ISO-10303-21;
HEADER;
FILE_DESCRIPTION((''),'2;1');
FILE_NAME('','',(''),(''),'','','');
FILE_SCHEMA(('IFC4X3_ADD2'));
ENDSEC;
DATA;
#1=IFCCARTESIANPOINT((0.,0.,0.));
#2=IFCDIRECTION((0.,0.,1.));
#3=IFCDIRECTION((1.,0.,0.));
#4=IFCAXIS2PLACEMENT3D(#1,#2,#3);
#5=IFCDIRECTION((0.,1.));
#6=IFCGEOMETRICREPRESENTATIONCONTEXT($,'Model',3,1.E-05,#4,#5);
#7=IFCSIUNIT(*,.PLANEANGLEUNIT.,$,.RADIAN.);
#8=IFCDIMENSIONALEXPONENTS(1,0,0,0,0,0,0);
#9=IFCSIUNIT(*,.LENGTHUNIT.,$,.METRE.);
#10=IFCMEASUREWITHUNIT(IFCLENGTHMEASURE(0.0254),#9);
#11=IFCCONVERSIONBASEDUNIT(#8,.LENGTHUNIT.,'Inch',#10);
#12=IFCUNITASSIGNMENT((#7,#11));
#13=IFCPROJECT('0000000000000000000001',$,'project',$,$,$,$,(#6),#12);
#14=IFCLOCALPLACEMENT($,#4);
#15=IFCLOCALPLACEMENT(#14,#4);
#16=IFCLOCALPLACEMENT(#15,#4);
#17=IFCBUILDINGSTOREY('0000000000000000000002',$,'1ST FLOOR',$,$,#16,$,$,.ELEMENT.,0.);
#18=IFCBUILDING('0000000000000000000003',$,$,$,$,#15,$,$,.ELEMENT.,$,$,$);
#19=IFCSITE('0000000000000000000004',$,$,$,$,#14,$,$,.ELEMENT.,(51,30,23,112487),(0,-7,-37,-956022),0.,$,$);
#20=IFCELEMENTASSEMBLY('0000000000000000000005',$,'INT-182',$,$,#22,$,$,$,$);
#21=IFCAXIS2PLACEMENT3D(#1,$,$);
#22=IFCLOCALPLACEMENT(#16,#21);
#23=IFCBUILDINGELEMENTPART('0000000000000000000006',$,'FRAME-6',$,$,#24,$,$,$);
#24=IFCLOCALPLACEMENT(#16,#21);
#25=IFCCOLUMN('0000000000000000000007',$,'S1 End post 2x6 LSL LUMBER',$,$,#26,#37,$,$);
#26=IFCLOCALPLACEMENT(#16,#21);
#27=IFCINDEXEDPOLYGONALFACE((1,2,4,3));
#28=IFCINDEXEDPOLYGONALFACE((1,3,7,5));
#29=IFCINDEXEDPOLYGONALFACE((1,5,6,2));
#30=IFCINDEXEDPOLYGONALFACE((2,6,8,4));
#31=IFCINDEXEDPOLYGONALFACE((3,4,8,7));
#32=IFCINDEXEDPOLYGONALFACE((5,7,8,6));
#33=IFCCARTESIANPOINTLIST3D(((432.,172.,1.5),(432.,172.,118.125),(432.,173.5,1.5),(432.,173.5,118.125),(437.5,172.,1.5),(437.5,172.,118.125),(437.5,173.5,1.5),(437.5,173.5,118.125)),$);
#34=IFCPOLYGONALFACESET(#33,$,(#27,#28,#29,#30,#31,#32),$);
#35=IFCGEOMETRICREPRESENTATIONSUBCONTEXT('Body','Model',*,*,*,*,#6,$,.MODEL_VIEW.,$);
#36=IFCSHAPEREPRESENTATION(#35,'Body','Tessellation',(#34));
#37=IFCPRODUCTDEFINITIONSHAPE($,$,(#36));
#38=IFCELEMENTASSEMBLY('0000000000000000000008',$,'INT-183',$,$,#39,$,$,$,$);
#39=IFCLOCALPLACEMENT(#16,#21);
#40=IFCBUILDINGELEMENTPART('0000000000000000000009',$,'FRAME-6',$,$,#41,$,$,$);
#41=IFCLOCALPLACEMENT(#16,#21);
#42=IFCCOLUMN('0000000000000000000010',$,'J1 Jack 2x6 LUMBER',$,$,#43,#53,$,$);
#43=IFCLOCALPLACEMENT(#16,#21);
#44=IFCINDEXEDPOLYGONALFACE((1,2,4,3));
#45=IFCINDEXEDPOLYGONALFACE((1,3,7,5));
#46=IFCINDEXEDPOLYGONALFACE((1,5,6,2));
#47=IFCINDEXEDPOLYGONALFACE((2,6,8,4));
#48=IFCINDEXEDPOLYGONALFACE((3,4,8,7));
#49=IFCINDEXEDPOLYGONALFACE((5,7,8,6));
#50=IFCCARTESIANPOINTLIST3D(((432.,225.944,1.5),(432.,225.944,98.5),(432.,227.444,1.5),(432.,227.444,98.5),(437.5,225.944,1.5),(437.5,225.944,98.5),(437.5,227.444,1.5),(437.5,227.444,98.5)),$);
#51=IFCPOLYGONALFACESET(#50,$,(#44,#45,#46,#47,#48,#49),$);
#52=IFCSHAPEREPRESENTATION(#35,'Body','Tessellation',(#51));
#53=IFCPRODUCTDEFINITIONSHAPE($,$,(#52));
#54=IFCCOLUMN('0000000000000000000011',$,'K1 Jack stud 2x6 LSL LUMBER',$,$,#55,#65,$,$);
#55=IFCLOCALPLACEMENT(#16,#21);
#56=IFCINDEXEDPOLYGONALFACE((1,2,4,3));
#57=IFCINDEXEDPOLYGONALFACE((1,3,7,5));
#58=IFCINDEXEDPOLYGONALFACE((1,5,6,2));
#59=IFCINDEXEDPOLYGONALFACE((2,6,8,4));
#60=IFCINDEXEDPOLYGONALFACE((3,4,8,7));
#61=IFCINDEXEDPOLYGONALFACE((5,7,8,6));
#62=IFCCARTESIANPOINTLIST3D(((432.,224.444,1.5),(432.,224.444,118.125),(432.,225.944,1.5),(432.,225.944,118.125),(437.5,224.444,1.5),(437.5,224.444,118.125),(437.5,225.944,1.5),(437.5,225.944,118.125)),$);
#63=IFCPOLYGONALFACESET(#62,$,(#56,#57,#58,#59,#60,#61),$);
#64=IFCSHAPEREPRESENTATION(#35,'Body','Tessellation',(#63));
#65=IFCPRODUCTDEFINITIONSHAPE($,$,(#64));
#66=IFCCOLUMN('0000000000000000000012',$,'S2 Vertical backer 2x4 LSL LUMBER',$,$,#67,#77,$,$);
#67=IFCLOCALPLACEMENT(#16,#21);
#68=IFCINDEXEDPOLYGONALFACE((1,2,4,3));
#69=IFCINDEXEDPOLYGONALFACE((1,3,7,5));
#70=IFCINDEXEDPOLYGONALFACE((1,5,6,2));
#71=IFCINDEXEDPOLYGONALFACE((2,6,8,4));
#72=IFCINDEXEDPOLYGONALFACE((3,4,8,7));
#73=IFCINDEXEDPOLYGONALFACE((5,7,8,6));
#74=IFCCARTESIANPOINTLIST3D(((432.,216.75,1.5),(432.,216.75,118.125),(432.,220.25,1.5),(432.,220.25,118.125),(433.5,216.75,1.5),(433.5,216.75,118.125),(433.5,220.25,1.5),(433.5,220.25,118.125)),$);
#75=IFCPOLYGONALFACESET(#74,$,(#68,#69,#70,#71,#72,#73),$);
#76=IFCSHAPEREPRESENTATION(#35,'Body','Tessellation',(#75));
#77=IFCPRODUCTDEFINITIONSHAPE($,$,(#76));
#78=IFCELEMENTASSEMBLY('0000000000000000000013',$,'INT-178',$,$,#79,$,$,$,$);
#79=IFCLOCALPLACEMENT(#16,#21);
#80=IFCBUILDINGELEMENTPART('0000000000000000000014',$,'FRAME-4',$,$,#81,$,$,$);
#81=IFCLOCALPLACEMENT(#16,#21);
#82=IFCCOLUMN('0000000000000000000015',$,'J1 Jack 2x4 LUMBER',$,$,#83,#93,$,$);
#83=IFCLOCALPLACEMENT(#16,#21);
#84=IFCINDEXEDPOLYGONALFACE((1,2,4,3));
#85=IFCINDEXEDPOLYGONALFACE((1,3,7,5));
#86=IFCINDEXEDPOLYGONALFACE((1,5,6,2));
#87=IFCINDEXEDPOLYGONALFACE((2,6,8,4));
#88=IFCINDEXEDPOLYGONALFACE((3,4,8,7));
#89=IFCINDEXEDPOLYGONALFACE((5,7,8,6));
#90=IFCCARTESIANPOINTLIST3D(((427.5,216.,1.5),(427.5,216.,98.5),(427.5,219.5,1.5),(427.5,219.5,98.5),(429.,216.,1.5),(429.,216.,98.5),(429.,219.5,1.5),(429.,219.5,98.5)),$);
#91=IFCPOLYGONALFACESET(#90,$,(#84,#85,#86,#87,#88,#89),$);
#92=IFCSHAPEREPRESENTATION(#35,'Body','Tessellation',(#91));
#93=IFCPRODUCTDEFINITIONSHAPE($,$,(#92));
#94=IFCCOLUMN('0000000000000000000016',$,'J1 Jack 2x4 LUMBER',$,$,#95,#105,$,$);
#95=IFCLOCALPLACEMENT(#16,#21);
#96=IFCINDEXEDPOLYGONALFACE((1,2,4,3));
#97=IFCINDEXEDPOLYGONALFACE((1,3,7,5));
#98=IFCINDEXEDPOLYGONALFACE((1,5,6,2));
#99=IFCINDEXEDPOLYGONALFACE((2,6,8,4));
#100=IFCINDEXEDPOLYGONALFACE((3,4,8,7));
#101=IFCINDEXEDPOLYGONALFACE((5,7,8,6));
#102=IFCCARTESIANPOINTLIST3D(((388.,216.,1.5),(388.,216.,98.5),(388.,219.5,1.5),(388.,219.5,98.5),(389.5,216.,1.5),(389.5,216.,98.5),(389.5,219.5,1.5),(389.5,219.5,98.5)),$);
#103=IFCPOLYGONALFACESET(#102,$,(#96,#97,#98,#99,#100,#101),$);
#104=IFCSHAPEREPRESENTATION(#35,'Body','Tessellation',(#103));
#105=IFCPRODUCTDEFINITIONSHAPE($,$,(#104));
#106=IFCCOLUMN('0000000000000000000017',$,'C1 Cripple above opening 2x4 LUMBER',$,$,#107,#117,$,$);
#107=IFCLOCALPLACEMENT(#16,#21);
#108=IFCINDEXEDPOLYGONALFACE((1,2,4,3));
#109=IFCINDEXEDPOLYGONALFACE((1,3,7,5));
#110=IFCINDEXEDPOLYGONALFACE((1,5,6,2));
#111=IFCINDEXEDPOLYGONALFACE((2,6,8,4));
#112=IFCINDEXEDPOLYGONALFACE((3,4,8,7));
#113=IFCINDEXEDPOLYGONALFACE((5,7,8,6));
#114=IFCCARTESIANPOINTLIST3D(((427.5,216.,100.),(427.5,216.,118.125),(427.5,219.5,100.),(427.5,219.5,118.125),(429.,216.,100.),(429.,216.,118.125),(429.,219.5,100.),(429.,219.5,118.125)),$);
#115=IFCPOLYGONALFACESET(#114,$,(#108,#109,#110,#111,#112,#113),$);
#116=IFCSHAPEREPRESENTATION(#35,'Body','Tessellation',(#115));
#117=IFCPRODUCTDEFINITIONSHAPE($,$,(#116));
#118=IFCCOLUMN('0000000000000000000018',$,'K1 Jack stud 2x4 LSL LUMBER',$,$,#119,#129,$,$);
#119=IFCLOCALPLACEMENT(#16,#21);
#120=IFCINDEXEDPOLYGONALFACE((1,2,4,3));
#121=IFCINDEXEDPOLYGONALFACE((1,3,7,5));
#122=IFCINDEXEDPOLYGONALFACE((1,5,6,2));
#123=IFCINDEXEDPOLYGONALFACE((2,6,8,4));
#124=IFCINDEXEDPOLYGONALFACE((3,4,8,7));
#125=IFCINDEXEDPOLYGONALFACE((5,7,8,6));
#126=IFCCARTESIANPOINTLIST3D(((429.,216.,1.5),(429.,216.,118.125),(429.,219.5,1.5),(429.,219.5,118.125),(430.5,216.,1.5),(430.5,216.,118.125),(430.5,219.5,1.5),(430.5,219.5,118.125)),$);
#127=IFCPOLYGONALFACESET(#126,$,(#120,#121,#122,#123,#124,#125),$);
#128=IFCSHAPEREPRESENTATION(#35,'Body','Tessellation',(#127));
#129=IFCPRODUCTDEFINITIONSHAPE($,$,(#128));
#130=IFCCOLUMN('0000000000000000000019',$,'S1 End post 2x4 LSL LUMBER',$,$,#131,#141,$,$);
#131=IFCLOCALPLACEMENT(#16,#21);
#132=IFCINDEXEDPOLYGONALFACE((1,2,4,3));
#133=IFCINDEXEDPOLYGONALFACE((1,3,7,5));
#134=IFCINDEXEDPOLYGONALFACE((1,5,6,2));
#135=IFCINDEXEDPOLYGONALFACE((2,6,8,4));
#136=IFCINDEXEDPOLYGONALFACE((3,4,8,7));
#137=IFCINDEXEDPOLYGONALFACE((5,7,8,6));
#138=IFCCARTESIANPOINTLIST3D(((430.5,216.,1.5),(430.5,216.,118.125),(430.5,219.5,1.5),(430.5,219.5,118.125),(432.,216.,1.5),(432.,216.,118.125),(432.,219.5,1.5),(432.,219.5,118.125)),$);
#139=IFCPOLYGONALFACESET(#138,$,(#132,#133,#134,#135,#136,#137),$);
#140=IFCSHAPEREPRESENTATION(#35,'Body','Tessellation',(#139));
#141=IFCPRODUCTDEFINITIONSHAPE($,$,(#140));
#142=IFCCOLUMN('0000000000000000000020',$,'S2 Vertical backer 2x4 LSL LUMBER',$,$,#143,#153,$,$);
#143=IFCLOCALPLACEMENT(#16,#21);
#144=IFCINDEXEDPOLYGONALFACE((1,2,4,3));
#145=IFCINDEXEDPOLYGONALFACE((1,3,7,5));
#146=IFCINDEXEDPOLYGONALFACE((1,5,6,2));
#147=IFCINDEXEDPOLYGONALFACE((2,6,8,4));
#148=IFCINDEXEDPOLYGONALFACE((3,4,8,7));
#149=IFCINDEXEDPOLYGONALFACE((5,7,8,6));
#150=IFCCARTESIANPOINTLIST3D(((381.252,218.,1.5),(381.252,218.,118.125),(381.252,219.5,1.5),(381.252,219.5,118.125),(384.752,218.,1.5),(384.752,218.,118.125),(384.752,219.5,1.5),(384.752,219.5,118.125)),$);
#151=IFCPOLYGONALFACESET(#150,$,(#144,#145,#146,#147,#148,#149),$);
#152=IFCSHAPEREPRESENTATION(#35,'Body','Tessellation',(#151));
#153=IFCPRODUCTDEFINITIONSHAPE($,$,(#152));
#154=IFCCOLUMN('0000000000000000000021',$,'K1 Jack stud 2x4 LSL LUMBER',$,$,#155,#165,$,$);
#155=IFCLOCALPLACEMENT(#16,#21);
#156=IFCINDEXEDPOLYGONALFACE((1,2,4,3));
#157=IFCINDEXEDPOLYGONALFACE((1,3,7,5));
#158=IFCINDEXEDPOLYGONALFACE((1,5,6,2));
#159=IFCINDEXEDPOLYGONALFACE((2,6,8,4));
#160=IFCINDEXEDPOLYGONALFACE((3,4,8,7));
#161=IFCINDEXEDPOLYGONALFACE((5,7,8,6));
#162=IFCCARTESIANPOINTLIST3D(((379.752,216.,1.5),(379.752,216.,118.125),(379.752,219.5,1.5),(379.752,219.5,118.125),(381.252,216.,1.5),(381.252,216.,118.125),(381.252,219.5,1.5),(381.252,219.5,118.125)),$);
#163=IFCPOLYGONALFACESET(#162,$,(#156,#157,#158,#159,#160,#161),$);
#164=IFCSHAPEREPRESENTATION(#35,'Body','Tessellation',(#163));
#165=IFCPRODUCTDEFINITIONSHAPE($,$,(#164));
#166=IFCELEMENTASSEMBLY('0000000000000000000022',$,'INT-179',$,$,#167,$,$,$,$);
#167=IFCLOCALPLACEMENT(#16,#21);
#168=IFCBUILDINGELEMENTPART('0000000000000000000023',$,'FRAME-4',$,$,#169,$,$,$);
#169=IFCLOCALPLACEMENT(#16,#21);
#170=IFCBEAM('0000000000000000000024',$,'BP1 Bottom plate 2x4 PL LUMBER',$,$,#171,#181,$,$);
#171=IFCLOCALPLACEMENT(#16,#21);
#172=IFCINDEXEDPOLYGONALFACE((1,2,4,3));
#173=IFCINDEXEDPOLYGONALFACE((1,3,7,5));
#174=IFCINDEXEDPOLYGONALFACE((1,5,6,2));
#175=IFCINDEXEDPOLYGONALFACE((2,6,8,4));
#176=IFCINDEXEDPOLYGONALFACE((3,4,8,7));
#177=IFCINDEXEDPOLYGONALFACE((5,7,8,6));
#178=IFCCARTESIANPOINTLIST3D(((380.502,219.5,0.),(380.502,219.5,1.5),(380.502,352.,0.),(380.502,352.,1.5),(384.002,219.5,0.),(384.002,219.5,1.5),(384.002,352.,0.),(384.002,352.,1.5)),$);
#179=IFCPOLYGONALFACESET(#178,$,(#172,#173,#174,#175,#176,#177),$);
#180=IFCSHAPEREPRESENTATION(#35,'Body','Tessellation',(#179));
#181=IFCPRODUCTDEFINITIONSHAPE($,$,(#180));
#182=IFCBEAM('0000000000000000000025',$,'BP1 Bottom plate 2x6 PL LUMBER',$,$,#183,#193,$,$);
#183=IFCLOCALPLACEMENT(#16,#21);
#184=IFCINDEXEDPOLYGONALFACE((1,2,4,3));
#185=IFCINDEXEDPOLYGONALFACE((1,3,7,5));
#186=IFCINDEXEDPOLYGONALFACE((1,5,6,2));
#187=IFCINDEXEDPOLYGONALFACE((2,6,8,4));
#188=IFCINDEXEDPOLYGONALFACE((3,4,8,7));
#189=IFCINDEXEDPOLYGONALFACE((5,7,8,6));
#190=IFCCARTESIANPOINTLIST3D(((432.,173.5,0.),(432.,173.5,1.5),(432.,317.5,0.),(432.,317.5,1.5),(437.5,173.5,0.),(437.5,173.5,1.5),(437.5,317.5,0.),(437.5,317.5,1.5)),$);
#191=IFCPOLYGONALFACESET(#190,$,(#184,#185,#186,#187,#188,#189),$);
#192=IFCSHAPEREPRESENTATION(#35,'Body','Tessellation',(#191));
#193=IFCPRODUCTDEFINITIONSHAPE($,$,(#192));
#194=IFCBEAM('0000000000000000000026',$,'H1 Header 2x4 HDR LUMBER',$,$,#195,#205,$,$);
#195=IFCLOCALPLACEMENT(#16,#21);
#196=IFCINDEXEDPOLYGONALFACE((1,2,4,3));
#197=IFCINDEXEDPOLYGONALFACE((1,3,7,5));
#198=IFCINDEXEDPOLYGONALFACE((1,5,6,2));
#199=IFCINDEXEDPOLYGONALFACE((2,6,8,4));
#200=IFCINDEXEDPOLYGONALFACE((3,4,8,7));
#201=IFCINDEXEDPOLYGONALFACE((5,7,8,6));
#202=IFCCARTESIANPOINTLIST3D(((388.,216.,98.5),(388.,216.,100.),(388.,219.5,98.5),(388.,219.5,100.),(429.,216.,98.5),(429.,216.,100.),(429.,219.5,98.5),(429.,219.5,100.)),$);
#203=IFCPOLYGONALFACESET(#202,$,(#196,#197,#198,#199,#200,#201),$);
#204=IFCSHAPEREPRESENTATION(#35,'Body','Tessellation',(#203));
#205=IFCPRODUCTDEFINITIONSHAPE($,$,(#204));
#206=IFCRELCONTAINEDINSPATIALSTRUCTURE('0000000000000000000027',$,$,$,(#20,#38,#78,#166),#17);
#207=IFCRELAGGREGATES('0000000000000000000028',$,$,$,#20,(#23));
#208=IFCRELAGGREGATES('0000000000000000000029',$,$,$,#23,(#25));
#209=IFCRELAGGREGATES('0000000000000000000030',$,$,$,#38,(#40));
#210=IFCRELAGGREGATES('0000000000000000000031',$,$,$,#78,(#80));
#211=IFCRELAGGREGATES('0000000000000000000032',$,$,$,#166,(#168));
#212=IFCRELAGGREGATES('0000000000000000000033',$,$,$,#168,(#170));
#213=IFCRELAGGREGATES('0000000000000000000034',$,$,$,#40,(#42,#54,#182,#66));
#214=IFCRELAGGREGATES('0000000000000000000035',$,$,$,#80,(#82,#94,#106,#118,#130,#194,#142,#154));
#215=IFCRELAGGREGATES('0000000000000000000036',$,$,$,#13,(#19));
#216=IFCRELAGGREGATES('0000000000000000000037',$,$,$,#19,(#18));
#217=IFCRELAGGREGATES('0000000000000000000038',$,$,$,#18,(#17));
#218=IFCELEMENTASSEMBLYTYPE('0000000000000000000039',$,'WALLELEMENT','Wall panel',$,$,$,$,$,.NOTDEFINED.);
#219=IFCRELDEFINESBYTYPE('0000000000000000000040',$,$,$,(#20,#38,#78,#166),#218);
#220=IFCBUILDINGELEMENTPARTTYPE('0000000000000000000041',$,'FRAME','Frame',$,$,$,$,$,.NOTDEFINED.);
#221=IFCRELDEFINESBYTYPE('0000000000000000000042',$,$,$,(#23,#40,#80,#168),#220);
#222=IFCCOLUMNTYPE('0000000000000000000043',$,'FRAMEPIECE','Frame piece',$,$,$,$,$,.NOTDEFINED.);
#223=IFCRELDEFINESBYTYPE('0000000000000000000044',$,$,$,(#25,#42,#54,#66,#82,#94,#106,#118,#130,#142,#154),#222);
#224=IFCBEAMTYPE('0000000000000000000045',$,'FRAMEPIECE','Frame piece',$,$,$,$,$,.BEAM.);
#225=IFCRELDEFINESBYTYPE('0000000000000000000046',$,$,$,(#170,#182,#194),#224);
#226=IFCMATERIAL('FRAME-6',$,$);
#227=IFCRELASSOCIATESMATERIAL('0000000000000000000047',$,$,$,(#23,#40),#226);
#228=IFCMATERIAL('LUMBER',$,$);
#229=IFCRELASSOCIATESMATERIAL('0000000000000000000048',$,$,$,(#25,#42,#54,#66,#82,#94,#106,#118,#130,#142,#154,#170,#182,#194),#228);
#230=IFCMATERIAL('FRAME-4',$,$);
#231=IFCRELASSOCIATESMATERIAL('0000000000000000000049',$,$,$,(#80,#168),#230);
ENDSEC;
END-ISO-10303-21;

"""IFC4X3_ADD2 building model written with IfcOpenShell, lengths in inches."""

from ifc_helpers import new_model, entity, si_unit, converted_unit, direction, frame, origin_with_axes, origin_2d_with_axis, place, context, subcontext, project, spatial, rectangle, extrude, material, type_object, element, aggregate, save


model = new_model("IFC4X3_ADD2")

# Units and contexts
model_context = context("Model", 3, precision=1e-05, world=origin_with_axes(), true_north=direction((0.0, 1.0)))
body_context = subcontext(model_context, "Body", "Model", "MODEL_VIEW")
ifc_project = project(units=[si_unit("PLANEANGLEUNIT", "RADIAN"), converted_unit("LENGTHUNIT", "Inch", entity("IfcLengthMeasure", 0.0254), si_unit("LENGTHUNIT", "METRE"), dimensions=[1, 0, 0, 0, 0, 0, 0])], contexts=[model_context])

# Site, building, storey
site_placement = place(None, origin_with_axes())
site = spatial("IfcSite", under=ifc_project, at=site_placement, CompositionType="ELEMENT", RefLatitude=(51, 30, 23, 112487), RefLongitude=(0, -7, -37, -956022), RefElevation=0.0)
building_placement = place(site_placement, origin_with_axes())
building = spatial("IfcBuilding", under=site, at=building_placement, CompositionType="ELEMENT")
storey_placement = place(building_placement, origin_with_axes())
storey = spatial("IfcBuildingStorey", under=building, at=storey_placement, Name="1ST FLOOR", CompositionType="ELEMENT", Elevation=0.0)

# Element assembly, building element part, column
element_assembly_type_1 = type_object("IfcElementAssemblyType", Name="WALLELEMENT", Description="Wall panel", PredefinedType="NOTDEFINED")
assembly_1_placement = place(storey_placement, origin_with_axes())
assembly_1 = element("IfcElementAssembly", 1, at=assembly_1_placement, inside=storey, type_object=element_assembly_type_1, Name="INT-182")
ifc_material_1 = material(Name="FRAME-6")
building_element_part_type = type_object("IfcBuildingElementPartType", Name="FRAME", Description="Frame", PredefinedType="NOTDEFINED")
building_element_part_1_placement = place(storey_placement, origin_with_axes())
building_element_part_1 = element("IfcBuildingElementPart", 2, at=building_element_part_1_placement, type_object=building_element_part_type, material=ifc_material_1, Name="FRAME-6")
aggregate(assembly_1, [building_element_part_1])
ifc_material_2 = material(Name="LUMBER")
column_type = type_object("IfcColumnType", Name="FRAMEPIECE", Description="Frame piece", PredefinedType="NOTDEFINED")
column_1_placement = place(storey_placement, frame((434.75, 172.75, 1.5), z_axis=(0.0, 0.0, 1.0), x_axis=(0.0, -1.0, 0.0)))
column_1 = element("IfcColumn", 3, at=column_1_placement, type_object=column_type, material=ifc_material_2, Name="S1 End post 2x6 LSL LUMBER", context=body_context, shape_type="SweptSolid", body=[
    extrude(rectangle(XDim=1.5, YDim=5.5, at=origin_2d_with_axis()), origin_with_axes(), (0.0, 0.0, 1.0), 116.625),
])
aggregate(building_element_part_1, [column_1])

# Element assemblies, building element parts, columns
assembly_2_placement = place(storey_placement, origin_with_axes())
assembly_2 = element("IfcElementAssembly", 4, at=assembly_2_placement, inside=storey, type_object=element_assembly_type_1, Name="INT-183")
building_element_part_2_placement = place(storey_placement, origin_with_axes())
building_element_part_2 = element("IfcBuildingElementPart", 5, at=building_element_part_2_placement, type_object=building_element_part_type, material=ifc_material_1, Name="FRAME-6")
aggregate(assembly_2, [building_element_part_2])
column_2_placement = place(storey_placement, frame((434.75, 226.694, 98.5), z_axis=(0.0, 0.0, -1.0), x_axis=(0.0, 1.0, 0.0)))
column_2 = element("IfcColumn", 6, at=column_2_placement, type_object=column_type, material=ifc_material_2, Name="J1 Jack 2x6 LUMBER", context=body_context, shape_type="SweptSolid", body=[
    extrude(rectangle(XDim=1.5, YDim=5.5, at=origin_2d_with_axis()), origin_with_axes(), (0.0, 0.0, 1.0), 97.0),
])
column_3_placement = place(storey_placement, frame((434.75, 225.194, 118.125), z_axis=(0.0, 0.0, -1.0), x_axis=(0.0, 1.0, 0.0)))
column_3 = element("IfcColumn", 7, at=column_3_placement, type_object=column_type, material=ifc_material_2, Name="K1 Jack stud 2x6 LSL LUMBER", context=body_context, shape_type="SweptSolid", body=[
    extrude(rectangle(XDim=1.5, YDim=5.5, at=origin_2d_with_axis()), origin_with_axes(), (0.0, 0.0, 1.0), 116.625),
])
column_4_placement = place(storey_placement, frame((432.75, 218.5, 1.5), z_axis=(0.0, 0.0, 1.0), x_axis=(-1.0, 0.0, 0.0)))
column_4 = element("IfcColumn", 8, at=column_4_placement, type_object=column_type, material=ifc_material_2, Name="S2 Vertical backer 2x4 LSL LUMBER", context=body_context, shape_type="SweptSolid", body=[
    extrude(rectangle(XDim=1.5, YDim=3.5, at=origin_2d_with_axis()), origin_with_axes(), (0.0, 0.0, 1.0), 116.625),
])
assembly_3_placement = place(storey_placement, origin_with_axes())
assembly_3 = element("IfcElementAssembly", 9, at=assembly_3_placement, inside=storey, type_object=element_assembly_type_1, Name="INT-178")
ifc_material_3 = material(Name="FRAME-4")
building_element_part_3_placement = place(storey_placement, origin_with_axes())
building_element_part_3 = element("IfcBuildingElementPart", 10, at=building_element_part_3_placement, type_object=building_element_part_type, material=ifc_material_3, Name="FRAME-4")
aggregate(assembly_3, [building_element_part_3])
column_5_placement = place(storey_placement, frame((428.25, 217.75, 1.5), z_axis=(0.0, 0.0, 1.0), x_axis=(-1.0, 0.0, 0.0)))
column_5 = element("IfcColumn", 11, at=column_5_placement, type_object=column_type, material=ifc_material_2, Name="J1 Jack 2x4 LUMBER", context=body_context, shape_type="SweptSolid", body=[
    extrude(rectangle(XDim=1.5, YDim=3.5, at=origin_2d_with_axis()), origin_with_axes(), (0.0, 0.0, 1.0), 97.0),
])
column_6_placement = place(storey_placement, frame((388.75, 217.75, 98.5), z_axis=(0.0, 0.0, -1.0), x_axis=(1.0, 0.0, 0.0)))
column_6 = element("IfcColumn", 12, at=column_6_placement, type_object=column_type, material=ifc_material_2, Name="J1 Jack 2x4 LUMBER", context=body_context, shape_type="SweptSolid", body=[
    extrude(rectangle(XDim=1.5, YDim=3.5, at=origin_2d_with_axis()), origin_with_axes(), (0.0, 0.0, 1.0), 97.0),
])
column_7_placement = place(storey_placement, frame((428.25, 217.75, 100.0), z_axis=(0.0, 0.0, 1.0), x_axis=(-1.0, 0.0, 0.0)))
column_7 = element("IfcColumn", 13, at=column_7_placement, type_object=column_type, material=ifc_material_2, Name="C1 Cripple above opening 2x4 LUMBER", context=body_context, shape_type="SweptSolid", body=[
    extrude(rectangle(XDim=1.5, YDim=3.5, at=origin_2d_with_axis()), origin_with_axes(), (0.0, 0.0, 1.0), 18.125),
])
column_8_placement = place(storey_placement, frame((429.75, 217.75, 1.5), z_axis=(0.0, 0.0, 1.0), x_axis=(-1.0, 0.0, 0.0)))
column_8 = element("IfcColumn", 14, at=column_8_placement, type_object=column_type, material=ifc_material_2, Name="K1 Jack stud 2x4 LSL LUMBER", context=body_context, shape_type="SweptSolid", body=[
    extrude(rectangle(XDim=1.5, YDim=3.5, at=origin_2d_with_axis()), origin_with_axes(), (0.0, 0.0, 1.0), 116.625),
])
column_9_placement = place(storey_placement, frame((431.25, 217.75, 1.5), z_axis=(0.0, 0.0, 1.0), x_axis=(-1.0, 0.0, 0.0)))
column_9 = element("IfcColumn", 15, at=column_9_placement, type_object=column_type, material=ifc_material_2, Name="S1 End post 2x4 LSL LUMBER", context=body_context, shape_type="SweptSolid", body=[
    extrude(rectangle(XDim=1.5, YDim=3.5, at=origin_2d_with_axis()), origin_with_axes(), (0.0, 0.0, 1.0), 116.625),
])
column_10_placement = place(storey_placement, frame((383.002, 218.75, 1.5), z_axis=(0.0, 0.0, 1.0), x_axis=(0.0, -1.0, 0.0)))
column_10 = element("IfcColumn", 16, at=column_10_placement, type_object=column_type, material=ifc_material_2, Name="S2 Vertical backer 2x4 LSL LUMBER", context=body_context, shape_type="SweptSolid", body=[
    extrude(rectangle(XDim=1.5, YDim=3.5, at=origin_2d_with_axis()), origin_with_axes(), (0.0, 0.0, 1.0), 116.625),
])
column_11_placement = place(storey_placement, frame((380.502, 217.75, 1.5), z_axis=(0.0, 0.0, 1.0), x_axis=(-1.0, 0.0, 0.0)))
column_11 = element("IfcColumn", 17, at=column_11_placement, type_object=column_type, material=ifc_material_2, Name="K1 Jack stud 2x4 LSL LUMBER", context=body_context, shape_type="SweptSolid", body=[
    extrude(rectangle(XDim=1.5, YDim=3.5, at=origin_2d_with_axis()), origin_with_axes(), (0.0, 0.0, 1.0), 116.625),
])

# Element assembly, building element part, beam
assembly_4_placement = place(storey_placement, origin_with_axes())
assembly_4 = element("IfcElementAssembly", 18, at=assembly_4_placement, inside=storey, type_object=element_assembly_type_1, Name="INT-179")
building_element_part_4_placement = place(storey_placement, origin_with_axes())
building_element_part_4 = element("IfcBuildingElementPart", 19, at=building_element_part_4_placement, type_object=building_element_part_type, material=ifc_material_3, Name="FRAME-4")
aggregate(assembly_4, [building_element_part_4])
beam_type_1 = type_object("IfcBeamType", Name="FRAMEPIECE", Description="Frame piece", PredefinedType="BEAM")
beam_1_placement = place(storey_placement, frame((382.252, 219.5, 0.75), z_axis=(0.0, 1.0, 0.0), x_axis=(0.0, 0.0, 1.0)))
beam_1 = element("IfcBeam", 20, at=beam_1_placement, type_object=beam_type_1, material=ifc_material_2, Name="BP1 Bottom plate 2x4 PL LUMBER", context=body_context, shape_type="SweptSolid", body=[
    extrude(rectangle(XDim=1.5, YDim=3.5, at=origin_2d_with_axis()), origin_with_axes(), (0.0, 0.0, 1.0), 132.5),
])
aggregate(building_element_part_4, [beam_1])

# Beams
beam_2_placement = place(storey_placement, frame((434.75, 173.5, 0.75), z_axis=(0.0, 1.0, 0.0), x_axis=(0.0, 0.0, 1.0)))
beam_2 = element("IfcBeam", 21, at=beam_2_placement, type_object=beam_type_1, material=ifc_material_2, Name="BP1 Bottom plate 2x6 PL LUMBER", context=body_context, shape_type="SweptSolid", body=[
    extrude(rectangle(XDim=1.5, YDim=5.5, at=origin_2d_with_axis()), origin_with_axes(), (0.0, 0.0, 1.0), 144.0),
])
aggregate(building_element_part_2, [column_2, column_3, beam_2, column_4])
beam_3_placement = place(storey_placement, frame((429.0, 217.75, 99.25), z_axis=(-1.0, 0.0, 0.0), x_axis=(0.0, 0.0, 1.0)))
beam_3 = element("IfcBeam", 22, at=beam_3_placement, type_object=beam_type_1, material=ifc_material_2, Name="H1 Header 2x4 HDR LUMBER", context=body_context, shape_type="SweptSolid", body=[
    extrude(rectangle(XDim=1.5, YDim=3.5, at=origin_2d_with_axis()), origin_with_axes(), (0.0, 0.0, 1.0), 41.0),
])
aggregate(building_element_part_3, [column_5, column_6, column_7, column_8, column_9, beam_3, column_10, column_11])

save(model, "model.ifc")
